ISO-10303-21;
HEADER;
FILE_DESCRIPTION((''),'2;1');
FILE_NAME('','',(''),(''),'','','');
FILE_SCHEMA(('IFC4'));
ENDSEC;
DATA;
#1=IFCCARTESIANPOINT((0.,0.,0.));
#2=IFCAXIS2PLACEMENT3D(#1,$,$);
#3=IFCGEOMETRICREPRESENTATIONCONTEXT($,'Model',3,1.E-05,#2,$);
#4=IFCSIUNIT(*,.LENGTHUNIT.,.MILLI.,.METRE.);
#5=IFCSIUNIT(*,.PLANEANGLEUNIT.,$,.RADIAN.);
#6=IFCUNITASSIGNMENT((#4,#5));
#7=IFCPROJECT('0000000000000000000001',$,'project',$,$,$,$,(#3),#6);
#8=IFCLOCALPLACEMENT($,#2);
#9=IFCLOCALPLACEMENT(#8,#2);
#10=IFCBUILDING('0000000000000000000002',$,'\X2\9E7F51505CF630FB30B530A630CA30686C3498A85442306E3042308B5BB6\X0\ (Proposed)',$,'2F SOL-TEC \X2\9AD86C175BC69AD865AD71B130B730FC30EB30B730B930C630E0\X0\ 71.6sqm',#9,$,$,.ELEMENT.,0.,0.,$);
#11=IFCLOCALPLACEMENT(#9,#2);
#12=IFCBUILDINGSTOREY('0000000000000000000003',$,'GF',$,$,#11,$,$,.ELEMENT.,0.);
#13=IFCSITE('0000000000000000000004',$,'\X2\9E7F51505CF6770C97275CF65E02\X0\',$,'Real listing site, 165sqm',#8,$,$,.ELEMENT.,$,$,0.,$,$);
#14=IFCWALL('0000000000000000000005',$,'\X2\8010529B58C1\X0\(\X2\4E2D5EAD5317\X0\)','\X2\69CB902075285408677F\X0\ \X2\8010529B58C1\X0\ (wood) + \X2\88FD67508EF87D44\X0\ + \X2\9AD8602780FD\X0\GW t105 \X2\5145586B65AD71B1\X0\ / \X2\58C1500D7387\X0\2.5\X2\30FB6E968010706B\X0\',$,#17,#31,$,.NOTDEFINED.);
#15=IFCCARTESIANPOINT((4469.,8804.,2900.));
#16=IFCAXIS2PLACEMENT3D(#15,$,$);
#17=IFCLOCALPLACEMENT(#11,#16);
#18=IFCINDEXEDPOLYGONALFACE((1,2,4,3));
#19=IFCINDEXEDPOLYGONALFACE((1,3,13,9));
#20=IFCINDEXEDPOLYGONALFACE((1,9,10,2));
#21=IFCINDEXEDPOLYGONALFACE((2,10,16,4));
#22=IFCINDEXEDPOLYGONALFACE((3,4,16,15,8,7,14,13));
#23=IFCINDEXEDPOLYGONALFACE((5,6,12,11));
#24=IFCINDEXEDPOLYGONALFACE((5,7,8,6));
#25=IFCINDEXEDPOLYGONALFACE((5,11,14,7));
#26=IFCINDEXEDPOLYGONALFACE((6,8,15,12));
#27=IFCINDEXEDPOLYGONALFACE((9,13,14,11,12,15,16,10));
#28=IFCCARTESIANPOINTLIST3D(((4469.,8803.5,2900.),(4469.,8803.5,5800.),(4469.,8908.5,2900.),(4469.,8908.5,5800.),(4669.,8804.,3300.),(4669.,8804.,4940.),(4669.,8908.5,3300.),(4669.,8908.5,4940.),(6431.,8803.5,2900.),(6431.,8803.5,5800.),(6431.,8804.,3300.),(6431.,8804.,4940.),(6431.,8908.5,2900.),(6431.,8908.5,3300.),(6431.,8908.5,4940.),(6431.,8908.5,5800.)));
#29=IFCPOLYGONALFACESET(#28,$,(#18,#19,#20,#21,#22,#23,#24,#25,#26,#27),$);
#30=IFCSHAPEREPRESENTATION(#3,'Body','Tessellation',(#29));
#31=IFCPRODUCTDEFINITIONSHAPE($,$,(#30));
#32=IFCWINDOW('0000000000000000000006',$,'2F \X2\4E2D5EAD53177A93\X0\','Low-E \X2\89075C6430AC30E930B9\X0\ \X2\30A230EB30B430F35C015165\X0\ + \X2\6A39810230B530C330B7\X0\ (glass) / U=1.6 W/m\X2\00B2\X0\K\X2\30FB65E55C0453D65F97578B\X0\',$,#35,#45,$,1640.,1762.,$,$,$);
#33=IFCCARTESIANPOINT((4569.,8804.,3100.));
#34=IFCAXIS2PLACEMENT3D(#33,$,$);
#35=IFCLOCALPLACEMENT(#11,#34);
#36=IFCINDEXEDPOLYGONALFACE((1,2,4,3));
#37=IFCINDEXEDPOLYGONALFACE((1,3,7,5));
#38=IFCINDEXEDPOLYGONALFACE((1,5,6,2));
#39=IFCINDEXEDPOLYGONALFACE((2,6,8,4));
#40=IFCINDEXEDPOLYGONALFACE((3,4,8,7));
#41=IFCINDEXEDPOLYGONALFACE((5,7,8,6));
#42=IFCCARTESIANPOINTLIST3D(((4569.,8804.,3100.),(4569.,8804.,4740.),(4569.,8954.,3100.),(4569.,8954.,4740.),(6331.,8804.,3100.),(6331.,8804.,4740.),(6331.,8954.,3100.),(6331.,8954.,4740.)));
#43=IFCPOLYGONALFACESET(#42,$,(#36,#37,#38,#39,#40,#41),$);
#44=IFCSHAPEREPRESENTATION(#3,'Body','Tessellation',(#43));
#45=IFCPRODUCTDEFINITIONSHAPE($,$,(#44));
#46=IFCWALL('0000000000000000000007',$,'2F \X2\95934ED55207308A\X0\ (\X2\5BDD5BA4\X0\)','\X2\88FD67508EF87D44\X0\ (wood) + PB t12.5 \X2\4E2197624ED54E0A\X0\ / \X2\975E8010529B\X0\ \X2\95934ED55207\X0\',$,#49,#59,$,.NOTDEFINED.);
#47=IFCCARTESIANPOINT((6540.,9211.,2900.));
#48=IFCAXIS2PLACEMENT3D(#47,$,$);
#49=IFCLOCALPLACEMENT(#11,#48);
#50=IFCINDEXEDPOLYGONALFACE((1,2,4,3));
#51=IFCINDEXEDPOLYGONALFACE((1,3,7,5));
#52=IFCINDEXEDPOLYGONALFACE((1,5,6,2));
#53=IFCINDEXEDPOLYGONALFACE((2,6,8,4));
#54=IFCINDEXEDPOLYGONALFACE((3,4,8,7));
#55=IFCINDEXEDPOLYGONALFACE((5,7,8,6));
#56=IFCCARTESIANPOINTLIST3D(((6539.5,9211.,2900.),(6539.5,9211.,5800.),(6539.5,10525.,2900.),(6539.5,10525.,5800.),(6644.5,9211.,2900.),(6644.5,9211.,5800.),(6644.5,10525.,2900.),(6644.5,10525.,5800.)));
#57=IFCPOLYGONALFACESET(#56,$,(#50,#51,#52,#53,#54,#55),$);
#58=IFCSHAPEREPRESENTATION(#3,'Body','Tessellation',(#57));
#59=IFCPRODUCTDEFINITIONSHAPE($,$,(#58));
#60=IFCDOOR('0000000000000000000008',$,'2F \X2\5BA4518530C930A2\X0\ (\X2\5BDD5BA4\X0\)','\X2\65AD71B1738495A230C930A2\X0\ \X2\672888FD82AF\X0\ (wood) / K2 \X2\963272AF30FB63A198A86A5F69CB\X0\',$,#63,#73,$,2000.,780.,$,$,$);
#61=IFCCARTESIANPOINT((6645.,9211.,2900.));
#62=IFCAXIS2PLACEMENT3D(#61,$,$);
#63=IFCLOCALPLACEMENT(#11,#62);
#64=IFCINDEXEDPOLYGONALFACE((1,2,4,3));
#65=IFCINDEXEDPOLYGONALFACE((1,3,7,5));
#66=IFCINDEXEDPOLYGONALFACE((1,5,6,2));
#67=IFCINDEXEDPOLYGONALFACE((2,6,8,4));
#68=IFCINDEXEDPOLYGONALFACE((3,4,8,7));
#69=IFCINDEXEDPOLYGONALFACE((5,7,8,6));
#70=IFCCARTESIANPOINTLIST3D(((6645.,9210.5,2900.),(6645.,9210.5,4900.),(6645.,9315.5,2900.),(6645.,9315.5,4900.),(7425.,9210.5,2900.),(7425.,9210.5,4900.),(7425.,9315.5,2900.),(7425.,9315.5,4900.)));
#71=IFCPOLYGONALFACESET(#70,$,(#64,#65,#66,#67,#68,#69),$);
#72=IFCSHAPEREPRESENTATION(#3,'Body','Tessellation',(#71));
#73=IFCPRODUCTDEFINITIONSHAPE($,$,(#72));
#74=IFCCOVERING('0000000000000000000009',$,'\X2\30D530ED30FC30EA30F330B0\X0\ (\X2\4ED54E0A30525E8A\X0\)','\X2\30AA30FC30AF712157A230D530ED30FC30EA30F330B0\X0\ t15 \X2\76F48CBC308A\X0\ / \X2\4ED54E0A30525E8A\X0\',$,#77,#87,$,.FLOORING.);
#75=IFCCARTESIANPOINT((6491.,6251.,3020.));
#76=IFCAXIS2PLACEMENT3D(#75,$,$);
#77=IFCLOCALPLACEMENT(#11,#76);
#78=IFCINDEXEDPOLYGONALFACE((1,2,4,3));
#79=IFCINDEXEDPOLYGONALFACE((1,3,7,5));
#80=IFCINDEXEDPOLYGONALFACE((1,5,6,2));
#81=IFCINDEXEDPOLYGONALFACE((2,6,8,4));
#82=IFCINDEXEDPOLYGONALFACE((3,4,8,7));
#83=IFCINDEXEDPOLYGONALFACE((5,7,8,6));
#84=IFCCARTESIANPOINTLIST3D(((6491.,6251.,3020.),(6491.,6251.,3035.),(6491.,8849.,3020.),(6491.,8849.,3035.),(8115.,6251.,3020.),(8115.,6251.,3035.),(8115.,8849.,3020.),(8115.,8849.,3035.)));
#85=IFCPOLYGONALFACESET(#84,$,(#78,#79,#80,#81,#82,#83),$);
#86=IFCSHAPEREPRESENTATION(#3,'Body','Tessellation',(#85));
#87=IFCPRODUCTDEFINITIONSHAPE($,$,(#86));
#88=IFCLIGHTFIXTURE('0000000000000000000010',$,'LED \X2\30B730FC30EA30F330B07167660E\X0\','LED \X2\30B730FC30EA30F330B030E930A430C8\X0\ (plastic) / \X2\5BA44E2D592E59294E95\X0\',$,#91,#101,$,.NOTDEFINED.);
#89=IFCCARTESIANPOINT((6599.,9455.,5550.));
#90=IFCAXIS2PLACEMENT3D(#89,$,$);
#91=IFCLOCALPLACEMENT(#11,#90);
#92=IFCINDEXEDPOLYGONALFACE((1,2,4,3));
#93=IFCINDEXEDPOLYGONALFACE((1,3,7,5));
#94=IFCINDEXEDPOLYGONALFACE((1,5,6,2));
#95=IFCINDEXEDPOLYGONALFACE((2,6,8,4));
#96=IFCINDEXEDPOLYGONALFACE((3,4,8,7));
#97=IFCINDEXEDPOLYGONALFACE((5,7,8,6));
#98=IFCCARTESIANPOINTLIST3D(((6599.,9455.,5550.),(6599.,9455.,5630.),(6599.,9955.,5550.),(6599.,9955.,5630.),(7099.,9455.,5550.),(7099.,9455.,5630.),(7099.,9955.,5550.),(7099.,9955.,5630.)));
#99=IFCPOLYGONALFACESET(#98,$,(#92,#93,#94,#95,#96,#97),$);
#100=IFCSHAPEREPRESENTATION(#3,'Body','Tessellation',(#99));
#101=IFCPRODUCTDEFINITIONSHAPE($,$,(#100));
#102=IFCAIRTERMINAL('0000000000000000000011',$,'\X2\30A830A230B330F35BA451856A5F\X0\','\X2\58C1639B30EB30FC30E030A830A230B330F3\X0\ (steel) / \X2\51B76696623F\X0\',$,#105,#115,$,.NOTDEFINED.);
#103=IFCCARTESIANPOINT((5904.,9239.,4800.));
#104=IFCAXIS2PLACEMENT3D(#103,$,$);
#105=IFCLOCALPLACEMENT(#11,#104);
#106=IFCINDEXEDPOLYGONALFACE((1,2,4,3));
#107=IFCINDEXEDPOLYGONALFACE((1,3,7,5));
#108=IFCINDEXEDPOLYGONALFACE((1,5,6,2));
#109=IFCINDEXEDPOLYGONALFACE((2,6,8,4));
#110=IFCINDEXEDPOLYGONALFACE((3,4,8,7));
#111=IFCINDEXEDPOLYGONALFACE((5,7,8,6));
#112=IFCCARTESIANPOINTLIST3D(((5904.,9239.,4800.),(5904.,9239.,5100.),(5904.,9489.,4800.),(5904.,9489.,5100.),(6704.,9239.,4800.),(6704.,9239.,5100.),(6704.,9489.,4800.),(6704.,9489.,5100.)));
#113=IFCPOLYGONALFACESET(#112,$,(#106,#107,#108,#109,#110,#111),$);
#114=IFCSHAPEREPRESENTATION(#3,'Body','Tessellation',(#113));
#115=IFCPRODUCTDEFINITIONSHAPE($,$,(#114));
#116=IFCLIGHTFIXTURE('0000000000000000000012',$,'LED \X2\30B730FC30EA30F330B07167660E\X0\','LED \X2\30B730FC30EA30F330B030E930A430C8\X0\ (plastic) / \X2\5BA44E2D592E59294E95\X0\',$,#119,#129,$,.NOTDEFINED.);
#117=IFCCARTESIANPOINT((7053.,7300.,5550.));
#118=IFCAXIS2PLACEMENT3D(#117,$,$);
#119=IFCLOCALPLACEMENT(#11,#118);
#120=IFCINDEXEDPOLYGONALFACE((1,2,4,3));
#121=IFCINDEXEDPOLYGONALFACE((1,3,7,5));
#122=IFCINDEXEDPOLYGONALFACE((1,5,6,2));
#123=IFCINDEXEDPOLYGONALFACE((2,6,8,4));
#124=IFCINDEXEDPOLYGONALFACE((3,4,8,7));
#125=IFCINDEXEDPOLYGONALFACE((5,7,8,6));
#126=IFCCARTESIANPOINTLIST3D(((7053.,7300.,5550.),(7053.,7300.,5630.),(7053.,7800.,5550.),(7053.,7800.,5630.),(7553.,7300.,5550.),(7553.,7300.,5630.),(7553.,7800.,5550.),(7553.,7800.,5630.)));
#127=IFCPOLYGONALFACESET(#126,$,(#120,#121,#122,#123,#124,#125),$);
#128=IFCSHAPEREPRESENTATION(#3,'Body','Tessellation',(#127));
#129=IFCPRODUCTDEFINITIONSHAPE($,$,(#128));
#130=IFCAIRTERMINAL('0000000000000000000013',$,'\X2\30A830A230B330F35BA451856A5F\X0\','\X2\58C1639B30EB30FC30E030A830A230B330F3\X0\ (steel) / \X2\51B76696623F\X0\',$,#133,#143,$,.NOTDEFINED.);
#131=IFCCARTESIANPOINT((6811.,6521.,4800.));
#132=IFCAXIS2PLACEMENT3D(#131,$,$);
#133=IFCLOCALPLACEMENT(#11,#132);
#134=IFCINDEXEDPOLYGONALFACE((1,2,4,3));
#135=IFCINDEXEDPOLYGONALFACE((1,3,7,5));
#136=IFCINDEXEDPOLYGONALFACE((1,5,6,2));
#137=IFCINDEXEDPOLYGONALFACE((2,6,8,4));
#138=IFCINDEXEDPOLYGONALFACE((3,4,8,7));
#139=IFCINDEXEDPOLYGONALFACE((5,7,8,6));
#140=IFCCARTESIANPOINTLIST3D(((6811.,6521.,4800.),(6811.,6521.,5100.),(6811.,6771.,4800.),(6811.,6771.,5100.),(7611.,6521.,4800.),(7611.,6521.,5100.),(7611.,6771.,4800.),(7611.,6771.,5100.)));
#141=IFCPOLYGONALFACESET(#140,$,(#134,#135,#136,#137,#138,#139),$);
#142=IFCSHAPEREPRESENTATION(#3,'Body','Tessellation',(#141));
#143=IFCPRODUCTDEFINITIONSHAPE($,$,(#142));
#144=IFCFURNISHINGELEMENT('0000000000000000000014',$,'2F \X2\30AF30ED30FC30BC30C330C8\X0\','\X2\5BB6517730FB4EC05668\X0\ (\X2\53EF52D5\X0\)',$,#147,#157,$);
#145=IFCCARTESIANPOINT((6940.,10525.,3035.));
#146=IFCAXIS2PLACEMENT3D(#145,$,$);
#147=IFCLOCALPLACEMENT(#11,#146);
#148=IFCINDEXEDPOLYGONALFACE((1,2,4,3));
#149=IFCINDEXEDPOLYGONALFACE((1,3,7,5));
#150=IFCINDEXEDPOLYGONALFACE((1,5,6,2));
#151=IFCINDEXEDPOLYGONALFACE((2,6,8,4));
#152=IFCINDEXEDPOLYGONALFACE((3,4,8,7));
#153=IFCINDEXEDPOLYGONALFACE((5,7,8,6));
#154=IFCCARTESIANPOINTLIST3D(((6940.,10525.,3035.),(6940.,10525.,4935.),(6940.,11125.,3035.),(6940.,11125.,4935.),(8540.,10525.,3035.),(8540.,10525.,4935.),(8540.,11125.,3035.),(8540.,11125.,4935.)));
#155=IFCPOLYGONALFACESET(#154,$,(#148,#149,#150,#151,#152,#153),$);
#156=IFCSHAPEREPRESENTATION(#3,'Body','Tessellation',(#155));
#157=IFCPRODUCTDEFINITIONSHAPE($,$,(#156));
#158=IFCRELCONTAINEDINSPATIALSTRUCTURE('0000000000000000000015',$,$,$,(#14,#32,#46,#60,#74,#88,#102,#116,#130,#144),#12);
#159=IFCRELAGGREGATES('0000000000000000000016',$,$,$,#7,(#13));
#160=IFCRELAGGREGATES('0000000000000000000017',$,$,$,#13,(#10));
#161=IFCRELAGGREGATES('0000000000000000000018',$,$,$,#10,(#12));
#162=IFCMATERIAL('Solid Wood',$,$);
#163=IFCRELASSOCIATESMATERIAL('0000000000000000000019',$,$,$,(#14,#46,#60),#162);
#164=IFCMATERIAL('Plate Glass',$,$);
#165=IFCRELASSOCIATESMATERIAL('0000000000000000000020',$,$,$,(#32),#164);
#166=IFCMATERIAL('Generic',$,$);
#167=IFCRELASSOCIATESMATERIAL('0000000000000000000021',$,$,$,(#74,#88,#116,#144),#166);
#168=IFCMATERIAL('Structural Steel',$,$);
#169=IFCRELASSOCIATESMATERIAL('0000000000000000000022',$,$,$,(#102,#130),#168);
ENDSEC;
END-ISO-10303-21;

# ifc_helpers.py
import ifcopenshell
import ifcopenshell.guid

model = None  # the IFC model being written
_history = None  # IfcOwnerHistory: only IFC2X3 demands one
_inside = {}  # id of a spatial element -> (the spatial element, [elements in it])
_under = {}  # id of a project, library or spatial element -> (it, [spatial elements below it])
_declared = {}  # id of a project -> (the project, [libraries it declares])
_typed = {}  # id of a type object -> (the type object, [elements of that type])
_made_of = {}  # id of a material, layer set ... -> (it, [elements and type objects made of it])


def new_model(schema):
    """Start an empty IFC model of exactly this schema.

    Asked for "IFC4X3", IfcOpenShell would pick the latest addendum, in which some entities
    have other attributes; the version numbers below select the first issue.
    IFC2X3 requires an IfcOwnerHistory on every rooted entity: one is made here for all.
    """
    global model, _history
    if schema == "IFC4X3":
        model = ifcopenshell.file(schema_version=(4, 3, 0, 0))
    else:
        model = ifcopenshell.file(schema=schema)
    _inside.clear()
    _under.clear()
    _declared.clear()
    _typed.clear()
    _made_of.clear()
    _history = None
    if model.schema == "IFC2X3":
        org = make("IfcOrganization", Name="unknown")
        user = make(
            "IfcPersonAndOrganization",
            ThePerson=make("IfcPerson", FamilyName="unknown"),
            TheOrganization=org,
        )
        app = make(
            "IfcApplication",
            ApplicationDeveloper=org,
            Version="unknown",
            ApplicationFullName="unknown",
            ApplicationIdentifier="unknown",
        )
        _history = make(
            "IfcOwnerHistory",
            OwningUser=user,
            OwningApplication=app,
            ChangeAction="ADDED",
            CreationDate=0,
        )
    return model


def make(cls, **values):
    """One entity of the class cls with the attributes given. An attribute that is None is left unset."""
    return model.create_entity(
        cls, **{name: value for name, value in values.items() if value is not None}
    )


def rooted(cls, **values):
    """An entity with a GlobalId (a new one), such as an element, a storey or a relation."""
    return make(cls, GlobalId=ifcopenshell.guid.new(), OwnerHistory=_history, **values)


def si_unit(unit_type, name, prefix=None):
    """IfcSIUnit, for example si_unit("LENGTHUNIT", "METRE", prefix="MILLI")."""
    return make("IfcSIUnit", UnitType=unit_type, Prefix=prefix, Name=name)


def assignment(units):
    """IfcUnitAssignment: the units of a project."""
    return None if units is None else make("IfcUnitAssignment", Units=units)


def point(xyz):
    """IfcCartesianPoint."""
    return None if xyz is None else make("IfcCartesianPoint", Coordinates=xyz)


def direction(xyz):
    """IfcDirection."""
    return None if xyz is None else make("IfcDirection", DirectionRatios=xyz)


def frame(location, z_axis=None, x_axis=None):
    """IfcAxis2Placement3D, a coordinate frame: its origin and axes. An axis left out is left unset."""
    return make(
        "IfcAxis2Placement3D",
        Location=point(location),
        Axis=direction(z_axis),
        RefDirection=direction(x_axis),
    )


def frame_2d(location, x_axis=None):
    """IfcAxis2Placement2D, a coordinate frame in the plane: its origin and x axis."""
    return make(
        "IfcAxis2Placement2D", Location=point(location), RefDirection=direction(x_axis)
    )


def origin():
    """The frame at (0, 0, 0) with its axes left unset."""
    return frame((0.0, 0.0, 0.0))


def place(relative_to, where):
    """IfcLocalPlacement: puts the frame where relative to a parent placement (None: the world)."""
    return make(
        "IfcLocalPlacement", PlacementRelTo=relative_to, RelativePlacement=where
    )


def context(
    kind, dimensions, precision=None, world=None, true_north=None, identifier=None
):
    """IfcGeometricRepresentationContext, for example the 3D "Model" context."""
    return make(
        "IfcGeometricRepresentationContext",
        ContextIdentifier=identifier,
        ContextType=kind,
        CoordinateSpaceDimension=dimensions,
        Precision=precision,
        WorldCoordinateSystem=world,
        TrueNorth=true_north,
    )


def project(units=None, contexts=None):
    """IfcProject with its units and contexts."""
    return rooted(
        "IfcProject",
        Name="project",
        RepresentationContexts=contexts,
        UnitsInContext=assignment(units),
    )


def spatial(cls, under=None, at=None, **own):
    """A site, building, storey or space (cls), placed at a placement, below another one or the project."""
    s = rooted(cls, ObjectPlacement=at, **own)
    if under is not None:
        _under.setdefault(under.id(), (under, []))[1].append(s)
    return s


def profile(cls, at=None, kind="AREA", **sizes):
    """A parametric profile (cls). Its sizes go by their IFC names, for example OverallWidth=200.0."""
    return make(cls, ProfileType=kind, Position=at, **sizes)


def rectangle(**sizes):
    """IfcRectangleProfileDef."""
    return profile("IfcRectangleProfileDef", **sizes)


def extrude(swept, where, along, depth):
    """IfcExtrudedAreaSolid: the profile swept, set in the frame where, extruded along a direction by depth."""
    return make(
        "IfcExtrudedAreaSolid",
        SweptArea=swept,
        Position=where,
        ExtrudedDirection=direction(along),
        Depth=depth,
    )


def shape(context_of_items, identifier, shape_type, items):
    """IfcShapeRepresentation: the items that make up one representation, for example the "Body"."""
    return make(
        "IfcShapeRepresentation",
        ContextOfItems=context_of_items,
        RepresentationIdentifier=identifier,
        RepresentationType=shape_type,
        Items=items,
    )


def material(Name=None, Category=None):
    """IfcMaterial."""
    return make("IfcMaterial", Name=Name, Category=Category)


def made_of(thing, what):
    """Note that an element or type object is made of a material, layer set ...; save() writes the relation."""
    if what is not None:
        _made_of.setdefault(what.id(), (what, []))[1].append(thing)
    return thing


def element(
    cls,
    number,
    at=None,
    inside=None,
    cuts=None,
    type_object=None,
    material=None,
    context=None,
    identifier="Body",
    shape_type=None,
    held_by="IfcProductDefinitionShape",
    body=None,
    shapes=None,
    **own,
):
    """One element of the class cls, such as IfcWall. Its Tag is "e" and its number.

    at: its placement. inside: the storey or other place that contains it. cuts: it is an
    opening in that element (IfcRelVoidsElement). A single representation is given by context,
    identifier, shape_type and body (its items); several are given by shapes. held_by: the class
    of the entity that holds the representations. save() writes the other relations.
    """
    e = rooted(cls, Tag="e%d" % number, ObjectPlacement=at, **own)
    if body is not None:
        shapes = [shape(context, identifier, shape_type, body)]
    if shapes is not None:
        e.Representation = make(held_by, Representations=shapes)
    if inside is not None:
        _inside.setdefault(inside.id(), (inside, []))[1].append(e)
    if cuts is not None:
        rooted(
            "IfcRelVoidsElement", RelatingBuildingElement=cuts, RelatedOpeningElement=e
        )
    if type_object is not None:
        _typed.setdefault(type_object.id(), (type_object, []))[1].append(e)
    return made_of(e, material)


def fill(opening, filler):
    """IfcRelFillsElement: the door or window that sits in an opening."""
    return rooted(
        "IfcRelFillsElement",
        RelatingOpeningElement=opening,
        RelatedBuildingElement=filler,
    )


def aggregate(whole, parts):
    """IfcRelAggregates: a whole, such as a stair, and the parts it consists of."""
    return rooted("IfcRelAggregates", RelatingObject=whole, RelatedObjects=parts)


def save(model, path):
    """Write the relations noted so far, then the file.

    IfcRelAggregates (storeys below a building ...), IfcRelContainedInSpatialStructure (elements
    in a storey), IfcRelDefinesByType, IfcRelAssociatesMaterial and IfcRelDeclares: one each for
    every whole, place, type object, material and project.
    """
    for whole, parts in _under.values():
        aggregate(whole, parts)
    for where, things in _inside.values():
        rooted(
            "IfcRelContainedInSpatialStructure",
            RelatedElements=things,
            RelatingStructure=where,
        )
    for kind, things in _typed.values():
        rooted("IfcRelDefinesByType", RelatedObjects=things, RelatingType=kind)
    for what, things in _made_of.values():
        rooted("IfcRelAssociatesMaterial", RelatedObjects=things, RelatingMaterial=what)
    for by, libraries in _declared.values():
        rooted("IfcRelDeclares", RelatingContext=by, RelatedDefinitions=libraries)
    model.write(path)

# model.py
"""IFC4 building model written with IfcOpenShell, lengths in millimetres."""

from ifc_helpers import new_model, si_unit, frame, frame_2d, origin, place, context, project, spatial, rectangle, extrude, material, element, fill, save


model = new_model("IFC4")

# Units and contexts
model_context = context("Model", 3, precision=1e-05, world=origin())
ifc_project = project(units=[si_unit("LENGTHUNIT", "METRE", prefix="MILLI"), si_unit("PLANEANGLEUNIT", "RADIAN")], contexts=[model_context])

# Site, building, storey
site_placement = place(None, origin())
site = spatial("IfcSite", under=ifc_project, at=site_placement, Name="鹿児島県霧島市", ObjectType="Real listing site, 165sqm", CompositionType="ELEMENT", RefElevation=0.0)
building_placement = place(site_placement, origin())
building = spatial("IfcBuilding", under=site, at=building_placement, Name="鹿児島・サウナと水風呂のある家 (Proposed)", ObjectType="2F SOL-TEC 高気密高断熱シールシステム 71.6sqm", CompositionType="ELEMENT", ElevationOfRefHeight=0.0, ElevationOfTerrain=0.0)
storey_placement = place(building_placement, origin())
storey = spatial("IfcBuildingStorey", under=building, at=storey_placement, Name="GF", CompositionType="ELEMENT", Elevation=0.0)

# Shared definitions
ifc_material_1 = material(Name="Solid Wood")

# Wall, opening, window
wall_1_placement = place(storey_placement, frame((4469.0, 8804.0, 2900.0)))
wall_1 = element("IfcWall", 1, at=wall_1_placement, inside=storey, material=ifc_material_1, Name="耐力壁(中庭北)", Description="構造用合板 耐力壁 (wood) + 製材軸組 + 高性能GW t105 充填断熱 / 壁倍率2.5・準耐火", PredefinedType="NOTDEFINED", context=model_context, shape_type="SweptSolid", body=[
    extrude(rectangle(XDim=1962.0, YDim=105.0, at=frame_2d((981.0, 52.0))), frame((4469.0, 8804.0, 2900.0)), (0.0, 0.0, 1.0), 2900.0),
])
opening_placement = place(storey_placement, frame((4569.0, 8804.0, 3100.0)))
opening = element("IfcOpeningElement", 2, at=opening_placement, cuts=wall_1, PredefinedType="NOTDEFINED", context=model_context, shape_type="SweptSolid", body=[
    extrude(rectangle(XDim=1762.0, YDim=150.0, at=frame_2d((881.0, 75.0))), frame((4569.0, 8804.0, 3100.0)), (0.0, 0.0, 1.0), 1640.0),
])
ifc_material_2 = material(Name="Plate Glass")
window_placement = place(storey_placement, frame((4569.0, 8804.0, 3100.0)))
window = element("IfcWindow", 3, at=window_placement, inside=storey, material=ifc_material_2, Name="2F 中庭北窓", Description="Low-E 複層ガラス アルゴン封入 + 樹脂サッシ (glass) / U=1.6 W/m²K・日射取得型", OverallHeight=1640.0, OverallWidth=1762.0, context=model_context, shape_type="SweptSolid", body=[
    extrude(rectangle(XDim=1762.0, YDim=150.0, at=frame_2d((881.0, 75.0))), frame((4569.0, 8804.0, 3100.0)), (0.0, 0.0, 1.0), 1640.0),
])
fill(opening, window)

# Wall
wall_2_placement = place(storey_placement, frame((6540.0, 9211.0, 2900.0)))
element("IfcWall", 4, at=wall_2_placement, inside=storey, material=ifc_material_1, Name="2F 間仕切り (寝室)", Description="製材軸組 (wood) + PB t12.5 両面仕上 / 非耐力 間仕切", PredefinedType="NOTDEFINED", context=model_context, shape_type="SweptSolid", body=[
    extrude(rectangle(XDim=105.0, YDim=1314.0, at=frame_2d((52.0, 657.0))), frame((6540.0, 9211.0, 2900.0)), (0.0, 0.0, 1.0), 2900.0),
])

# Door
door_placement = place(storey_placement, frame((6645.0, 9211.0, 2900.0)))
element("IfcDoor", 5, at=door_placement, inside=storey, material=ifc_material_1, Name="2F 室内ドア (寝室)", Description="断熱玄関ドア 木製芯 (wood) / K2 防犯・採風機構", OverallHeight=2000.0, OverallWidth=780.0, context=model_context, shape_type="SweptSolid", body=[
    extrude(rectangle(XDim=780.0, YDim=105.0, at=frame_2d((390.0, 52.0))), frame((6645.0, 9211.0, 2900.0)), (0.0, 0.0, 1.0), 2000.0),
])

# Covering
ifc_material_3 = material(Name="Generic")
covering_placement = place(storey_placement, frame((6491.0, 6251.0, 3020.0)))
element("IfcCovering", 6, at=covering_placement, inside=storey, material=ifc_material_3, Name="フローリング (仕上げ床)", Description="オーク無垢フローリング t15 直貼り / 仕上げ床", PredefinedType="FLOORING", context=model_context, shape_type="SweptSolid", body=[
    extrude(rectangle(XDim=1624.0, YDim=2598.0, at=frame_2d((812.0, 1299.0))), frame((6491.0, 6251.0, 3020.0)), (0.0, 0.0, 1.0), 15.0),
])

# Light fixture
light_fixture_1_placement = place(storey_placement, frame((6599.0, 9455.0, 5550.0)))
element("IfcLightFixture", 7, at=light_fixture_1_placement, inside=storey, material=ifc_material_3, Name="LED シーリング照明", Description="LED シーリングライト (plastic) / 室中央天井", PredefinedType="NOTDEFINED", context=model_context, shape_type="SweptSolid", body=[
    extrude(rectangle(XDim=500.0, YDim=500.0, at=frame_2d((250.0, 250.0))), frame((6599.0, 9455.0, 5550.0)), (0.0, 0.0, 1.0), 80.0),
])

# Air terminal
ifc_material_4 = material(Name="Structural Steel")
air_terminal_1_placement = place(storey_placement, frame((5904.0, 9239.0, 4800.0)))
element("IfcAirTerminal", 8, at=air_terminal_1_placement, inside=storey, material=ifc_material_4, Name="エアコン室内機", Description="壁掛ルームエアコン (steel) / 冷暖房", PredefinedType="NOTDEFINED", context=model_context, shape_type="SweptSolid", body=[
    extrude(rectangle(XDim=800.0, YDim=250.0, at=frame_2d((400.0, 125.0))), frame((5904.0, 9239.0, 4800.0)), (0.0, 0.0, 1.0), 300.0),
])

# Light fixture
light_fixture_2_placement = place(storey_placement, frame((7053.0, 7300.0, 5550.0)))
element("IfcLightFixture", 9, at=light_fixture_2_placement, inside=storey, material=ifc_material_3, Name="LED シーリング照明", Description="LED シーリングライト (plastic) / 室中央天井", PredefinedType="NOTDEFINED", context=model_context, shape_type="SweptSolid", body=[
    extrude(rectangle(XDim=500.0, YDim=500.0, at=frame_2d((250.0, 250.0))), frame((7053.0, 7300.0, 5550.0)), (0.0, 0.0, 1.0), 80.0),
])

# Air terminal
air_terminal_2_placement = place(storey_placement, frame((6811.0, 6521.0, 4800.0)))
element("IfcAirTerminal", 10, at=air_terminal_2_placement, inside=storey, material=ifc_material_4, Name="エアコン室内機", Description="壁掛ルームエアコン (steel) / 冷暖房", PredefinedType="NOTDEFINED", context=model_context, shape_type="SweptSolid", body=[
    extrude(rectangle(XDim=800.0, YDim=250.0, at=frame_2d((400.0, 125.0))), frame((6811.0, 6521.0, 4800.0)), (0.0, 0.0, 1.0), 300.0),
])

# Furnishing element
furnishing_placement = place(storey_placement, frame((6940.0, 10525.0, 3035.0)))
element("IfcFurnishingElement", 11, at=furnishing_placement, inside=storey, material=ifc_material_3, Name="2F クローゼット", Description="家具・什器 (可動)", context=model_context, shape_type="SweptSolid", body=[
    extrude(rectangle(XDim=1600.0, YDim=600.0, at=frame_2d((800.0, 300.0))), frame((6940.0, 10525.0, 3035.0)), (0.0, 0.0, 1.0), 1900.0),
])

save(model, "model.ifc")
